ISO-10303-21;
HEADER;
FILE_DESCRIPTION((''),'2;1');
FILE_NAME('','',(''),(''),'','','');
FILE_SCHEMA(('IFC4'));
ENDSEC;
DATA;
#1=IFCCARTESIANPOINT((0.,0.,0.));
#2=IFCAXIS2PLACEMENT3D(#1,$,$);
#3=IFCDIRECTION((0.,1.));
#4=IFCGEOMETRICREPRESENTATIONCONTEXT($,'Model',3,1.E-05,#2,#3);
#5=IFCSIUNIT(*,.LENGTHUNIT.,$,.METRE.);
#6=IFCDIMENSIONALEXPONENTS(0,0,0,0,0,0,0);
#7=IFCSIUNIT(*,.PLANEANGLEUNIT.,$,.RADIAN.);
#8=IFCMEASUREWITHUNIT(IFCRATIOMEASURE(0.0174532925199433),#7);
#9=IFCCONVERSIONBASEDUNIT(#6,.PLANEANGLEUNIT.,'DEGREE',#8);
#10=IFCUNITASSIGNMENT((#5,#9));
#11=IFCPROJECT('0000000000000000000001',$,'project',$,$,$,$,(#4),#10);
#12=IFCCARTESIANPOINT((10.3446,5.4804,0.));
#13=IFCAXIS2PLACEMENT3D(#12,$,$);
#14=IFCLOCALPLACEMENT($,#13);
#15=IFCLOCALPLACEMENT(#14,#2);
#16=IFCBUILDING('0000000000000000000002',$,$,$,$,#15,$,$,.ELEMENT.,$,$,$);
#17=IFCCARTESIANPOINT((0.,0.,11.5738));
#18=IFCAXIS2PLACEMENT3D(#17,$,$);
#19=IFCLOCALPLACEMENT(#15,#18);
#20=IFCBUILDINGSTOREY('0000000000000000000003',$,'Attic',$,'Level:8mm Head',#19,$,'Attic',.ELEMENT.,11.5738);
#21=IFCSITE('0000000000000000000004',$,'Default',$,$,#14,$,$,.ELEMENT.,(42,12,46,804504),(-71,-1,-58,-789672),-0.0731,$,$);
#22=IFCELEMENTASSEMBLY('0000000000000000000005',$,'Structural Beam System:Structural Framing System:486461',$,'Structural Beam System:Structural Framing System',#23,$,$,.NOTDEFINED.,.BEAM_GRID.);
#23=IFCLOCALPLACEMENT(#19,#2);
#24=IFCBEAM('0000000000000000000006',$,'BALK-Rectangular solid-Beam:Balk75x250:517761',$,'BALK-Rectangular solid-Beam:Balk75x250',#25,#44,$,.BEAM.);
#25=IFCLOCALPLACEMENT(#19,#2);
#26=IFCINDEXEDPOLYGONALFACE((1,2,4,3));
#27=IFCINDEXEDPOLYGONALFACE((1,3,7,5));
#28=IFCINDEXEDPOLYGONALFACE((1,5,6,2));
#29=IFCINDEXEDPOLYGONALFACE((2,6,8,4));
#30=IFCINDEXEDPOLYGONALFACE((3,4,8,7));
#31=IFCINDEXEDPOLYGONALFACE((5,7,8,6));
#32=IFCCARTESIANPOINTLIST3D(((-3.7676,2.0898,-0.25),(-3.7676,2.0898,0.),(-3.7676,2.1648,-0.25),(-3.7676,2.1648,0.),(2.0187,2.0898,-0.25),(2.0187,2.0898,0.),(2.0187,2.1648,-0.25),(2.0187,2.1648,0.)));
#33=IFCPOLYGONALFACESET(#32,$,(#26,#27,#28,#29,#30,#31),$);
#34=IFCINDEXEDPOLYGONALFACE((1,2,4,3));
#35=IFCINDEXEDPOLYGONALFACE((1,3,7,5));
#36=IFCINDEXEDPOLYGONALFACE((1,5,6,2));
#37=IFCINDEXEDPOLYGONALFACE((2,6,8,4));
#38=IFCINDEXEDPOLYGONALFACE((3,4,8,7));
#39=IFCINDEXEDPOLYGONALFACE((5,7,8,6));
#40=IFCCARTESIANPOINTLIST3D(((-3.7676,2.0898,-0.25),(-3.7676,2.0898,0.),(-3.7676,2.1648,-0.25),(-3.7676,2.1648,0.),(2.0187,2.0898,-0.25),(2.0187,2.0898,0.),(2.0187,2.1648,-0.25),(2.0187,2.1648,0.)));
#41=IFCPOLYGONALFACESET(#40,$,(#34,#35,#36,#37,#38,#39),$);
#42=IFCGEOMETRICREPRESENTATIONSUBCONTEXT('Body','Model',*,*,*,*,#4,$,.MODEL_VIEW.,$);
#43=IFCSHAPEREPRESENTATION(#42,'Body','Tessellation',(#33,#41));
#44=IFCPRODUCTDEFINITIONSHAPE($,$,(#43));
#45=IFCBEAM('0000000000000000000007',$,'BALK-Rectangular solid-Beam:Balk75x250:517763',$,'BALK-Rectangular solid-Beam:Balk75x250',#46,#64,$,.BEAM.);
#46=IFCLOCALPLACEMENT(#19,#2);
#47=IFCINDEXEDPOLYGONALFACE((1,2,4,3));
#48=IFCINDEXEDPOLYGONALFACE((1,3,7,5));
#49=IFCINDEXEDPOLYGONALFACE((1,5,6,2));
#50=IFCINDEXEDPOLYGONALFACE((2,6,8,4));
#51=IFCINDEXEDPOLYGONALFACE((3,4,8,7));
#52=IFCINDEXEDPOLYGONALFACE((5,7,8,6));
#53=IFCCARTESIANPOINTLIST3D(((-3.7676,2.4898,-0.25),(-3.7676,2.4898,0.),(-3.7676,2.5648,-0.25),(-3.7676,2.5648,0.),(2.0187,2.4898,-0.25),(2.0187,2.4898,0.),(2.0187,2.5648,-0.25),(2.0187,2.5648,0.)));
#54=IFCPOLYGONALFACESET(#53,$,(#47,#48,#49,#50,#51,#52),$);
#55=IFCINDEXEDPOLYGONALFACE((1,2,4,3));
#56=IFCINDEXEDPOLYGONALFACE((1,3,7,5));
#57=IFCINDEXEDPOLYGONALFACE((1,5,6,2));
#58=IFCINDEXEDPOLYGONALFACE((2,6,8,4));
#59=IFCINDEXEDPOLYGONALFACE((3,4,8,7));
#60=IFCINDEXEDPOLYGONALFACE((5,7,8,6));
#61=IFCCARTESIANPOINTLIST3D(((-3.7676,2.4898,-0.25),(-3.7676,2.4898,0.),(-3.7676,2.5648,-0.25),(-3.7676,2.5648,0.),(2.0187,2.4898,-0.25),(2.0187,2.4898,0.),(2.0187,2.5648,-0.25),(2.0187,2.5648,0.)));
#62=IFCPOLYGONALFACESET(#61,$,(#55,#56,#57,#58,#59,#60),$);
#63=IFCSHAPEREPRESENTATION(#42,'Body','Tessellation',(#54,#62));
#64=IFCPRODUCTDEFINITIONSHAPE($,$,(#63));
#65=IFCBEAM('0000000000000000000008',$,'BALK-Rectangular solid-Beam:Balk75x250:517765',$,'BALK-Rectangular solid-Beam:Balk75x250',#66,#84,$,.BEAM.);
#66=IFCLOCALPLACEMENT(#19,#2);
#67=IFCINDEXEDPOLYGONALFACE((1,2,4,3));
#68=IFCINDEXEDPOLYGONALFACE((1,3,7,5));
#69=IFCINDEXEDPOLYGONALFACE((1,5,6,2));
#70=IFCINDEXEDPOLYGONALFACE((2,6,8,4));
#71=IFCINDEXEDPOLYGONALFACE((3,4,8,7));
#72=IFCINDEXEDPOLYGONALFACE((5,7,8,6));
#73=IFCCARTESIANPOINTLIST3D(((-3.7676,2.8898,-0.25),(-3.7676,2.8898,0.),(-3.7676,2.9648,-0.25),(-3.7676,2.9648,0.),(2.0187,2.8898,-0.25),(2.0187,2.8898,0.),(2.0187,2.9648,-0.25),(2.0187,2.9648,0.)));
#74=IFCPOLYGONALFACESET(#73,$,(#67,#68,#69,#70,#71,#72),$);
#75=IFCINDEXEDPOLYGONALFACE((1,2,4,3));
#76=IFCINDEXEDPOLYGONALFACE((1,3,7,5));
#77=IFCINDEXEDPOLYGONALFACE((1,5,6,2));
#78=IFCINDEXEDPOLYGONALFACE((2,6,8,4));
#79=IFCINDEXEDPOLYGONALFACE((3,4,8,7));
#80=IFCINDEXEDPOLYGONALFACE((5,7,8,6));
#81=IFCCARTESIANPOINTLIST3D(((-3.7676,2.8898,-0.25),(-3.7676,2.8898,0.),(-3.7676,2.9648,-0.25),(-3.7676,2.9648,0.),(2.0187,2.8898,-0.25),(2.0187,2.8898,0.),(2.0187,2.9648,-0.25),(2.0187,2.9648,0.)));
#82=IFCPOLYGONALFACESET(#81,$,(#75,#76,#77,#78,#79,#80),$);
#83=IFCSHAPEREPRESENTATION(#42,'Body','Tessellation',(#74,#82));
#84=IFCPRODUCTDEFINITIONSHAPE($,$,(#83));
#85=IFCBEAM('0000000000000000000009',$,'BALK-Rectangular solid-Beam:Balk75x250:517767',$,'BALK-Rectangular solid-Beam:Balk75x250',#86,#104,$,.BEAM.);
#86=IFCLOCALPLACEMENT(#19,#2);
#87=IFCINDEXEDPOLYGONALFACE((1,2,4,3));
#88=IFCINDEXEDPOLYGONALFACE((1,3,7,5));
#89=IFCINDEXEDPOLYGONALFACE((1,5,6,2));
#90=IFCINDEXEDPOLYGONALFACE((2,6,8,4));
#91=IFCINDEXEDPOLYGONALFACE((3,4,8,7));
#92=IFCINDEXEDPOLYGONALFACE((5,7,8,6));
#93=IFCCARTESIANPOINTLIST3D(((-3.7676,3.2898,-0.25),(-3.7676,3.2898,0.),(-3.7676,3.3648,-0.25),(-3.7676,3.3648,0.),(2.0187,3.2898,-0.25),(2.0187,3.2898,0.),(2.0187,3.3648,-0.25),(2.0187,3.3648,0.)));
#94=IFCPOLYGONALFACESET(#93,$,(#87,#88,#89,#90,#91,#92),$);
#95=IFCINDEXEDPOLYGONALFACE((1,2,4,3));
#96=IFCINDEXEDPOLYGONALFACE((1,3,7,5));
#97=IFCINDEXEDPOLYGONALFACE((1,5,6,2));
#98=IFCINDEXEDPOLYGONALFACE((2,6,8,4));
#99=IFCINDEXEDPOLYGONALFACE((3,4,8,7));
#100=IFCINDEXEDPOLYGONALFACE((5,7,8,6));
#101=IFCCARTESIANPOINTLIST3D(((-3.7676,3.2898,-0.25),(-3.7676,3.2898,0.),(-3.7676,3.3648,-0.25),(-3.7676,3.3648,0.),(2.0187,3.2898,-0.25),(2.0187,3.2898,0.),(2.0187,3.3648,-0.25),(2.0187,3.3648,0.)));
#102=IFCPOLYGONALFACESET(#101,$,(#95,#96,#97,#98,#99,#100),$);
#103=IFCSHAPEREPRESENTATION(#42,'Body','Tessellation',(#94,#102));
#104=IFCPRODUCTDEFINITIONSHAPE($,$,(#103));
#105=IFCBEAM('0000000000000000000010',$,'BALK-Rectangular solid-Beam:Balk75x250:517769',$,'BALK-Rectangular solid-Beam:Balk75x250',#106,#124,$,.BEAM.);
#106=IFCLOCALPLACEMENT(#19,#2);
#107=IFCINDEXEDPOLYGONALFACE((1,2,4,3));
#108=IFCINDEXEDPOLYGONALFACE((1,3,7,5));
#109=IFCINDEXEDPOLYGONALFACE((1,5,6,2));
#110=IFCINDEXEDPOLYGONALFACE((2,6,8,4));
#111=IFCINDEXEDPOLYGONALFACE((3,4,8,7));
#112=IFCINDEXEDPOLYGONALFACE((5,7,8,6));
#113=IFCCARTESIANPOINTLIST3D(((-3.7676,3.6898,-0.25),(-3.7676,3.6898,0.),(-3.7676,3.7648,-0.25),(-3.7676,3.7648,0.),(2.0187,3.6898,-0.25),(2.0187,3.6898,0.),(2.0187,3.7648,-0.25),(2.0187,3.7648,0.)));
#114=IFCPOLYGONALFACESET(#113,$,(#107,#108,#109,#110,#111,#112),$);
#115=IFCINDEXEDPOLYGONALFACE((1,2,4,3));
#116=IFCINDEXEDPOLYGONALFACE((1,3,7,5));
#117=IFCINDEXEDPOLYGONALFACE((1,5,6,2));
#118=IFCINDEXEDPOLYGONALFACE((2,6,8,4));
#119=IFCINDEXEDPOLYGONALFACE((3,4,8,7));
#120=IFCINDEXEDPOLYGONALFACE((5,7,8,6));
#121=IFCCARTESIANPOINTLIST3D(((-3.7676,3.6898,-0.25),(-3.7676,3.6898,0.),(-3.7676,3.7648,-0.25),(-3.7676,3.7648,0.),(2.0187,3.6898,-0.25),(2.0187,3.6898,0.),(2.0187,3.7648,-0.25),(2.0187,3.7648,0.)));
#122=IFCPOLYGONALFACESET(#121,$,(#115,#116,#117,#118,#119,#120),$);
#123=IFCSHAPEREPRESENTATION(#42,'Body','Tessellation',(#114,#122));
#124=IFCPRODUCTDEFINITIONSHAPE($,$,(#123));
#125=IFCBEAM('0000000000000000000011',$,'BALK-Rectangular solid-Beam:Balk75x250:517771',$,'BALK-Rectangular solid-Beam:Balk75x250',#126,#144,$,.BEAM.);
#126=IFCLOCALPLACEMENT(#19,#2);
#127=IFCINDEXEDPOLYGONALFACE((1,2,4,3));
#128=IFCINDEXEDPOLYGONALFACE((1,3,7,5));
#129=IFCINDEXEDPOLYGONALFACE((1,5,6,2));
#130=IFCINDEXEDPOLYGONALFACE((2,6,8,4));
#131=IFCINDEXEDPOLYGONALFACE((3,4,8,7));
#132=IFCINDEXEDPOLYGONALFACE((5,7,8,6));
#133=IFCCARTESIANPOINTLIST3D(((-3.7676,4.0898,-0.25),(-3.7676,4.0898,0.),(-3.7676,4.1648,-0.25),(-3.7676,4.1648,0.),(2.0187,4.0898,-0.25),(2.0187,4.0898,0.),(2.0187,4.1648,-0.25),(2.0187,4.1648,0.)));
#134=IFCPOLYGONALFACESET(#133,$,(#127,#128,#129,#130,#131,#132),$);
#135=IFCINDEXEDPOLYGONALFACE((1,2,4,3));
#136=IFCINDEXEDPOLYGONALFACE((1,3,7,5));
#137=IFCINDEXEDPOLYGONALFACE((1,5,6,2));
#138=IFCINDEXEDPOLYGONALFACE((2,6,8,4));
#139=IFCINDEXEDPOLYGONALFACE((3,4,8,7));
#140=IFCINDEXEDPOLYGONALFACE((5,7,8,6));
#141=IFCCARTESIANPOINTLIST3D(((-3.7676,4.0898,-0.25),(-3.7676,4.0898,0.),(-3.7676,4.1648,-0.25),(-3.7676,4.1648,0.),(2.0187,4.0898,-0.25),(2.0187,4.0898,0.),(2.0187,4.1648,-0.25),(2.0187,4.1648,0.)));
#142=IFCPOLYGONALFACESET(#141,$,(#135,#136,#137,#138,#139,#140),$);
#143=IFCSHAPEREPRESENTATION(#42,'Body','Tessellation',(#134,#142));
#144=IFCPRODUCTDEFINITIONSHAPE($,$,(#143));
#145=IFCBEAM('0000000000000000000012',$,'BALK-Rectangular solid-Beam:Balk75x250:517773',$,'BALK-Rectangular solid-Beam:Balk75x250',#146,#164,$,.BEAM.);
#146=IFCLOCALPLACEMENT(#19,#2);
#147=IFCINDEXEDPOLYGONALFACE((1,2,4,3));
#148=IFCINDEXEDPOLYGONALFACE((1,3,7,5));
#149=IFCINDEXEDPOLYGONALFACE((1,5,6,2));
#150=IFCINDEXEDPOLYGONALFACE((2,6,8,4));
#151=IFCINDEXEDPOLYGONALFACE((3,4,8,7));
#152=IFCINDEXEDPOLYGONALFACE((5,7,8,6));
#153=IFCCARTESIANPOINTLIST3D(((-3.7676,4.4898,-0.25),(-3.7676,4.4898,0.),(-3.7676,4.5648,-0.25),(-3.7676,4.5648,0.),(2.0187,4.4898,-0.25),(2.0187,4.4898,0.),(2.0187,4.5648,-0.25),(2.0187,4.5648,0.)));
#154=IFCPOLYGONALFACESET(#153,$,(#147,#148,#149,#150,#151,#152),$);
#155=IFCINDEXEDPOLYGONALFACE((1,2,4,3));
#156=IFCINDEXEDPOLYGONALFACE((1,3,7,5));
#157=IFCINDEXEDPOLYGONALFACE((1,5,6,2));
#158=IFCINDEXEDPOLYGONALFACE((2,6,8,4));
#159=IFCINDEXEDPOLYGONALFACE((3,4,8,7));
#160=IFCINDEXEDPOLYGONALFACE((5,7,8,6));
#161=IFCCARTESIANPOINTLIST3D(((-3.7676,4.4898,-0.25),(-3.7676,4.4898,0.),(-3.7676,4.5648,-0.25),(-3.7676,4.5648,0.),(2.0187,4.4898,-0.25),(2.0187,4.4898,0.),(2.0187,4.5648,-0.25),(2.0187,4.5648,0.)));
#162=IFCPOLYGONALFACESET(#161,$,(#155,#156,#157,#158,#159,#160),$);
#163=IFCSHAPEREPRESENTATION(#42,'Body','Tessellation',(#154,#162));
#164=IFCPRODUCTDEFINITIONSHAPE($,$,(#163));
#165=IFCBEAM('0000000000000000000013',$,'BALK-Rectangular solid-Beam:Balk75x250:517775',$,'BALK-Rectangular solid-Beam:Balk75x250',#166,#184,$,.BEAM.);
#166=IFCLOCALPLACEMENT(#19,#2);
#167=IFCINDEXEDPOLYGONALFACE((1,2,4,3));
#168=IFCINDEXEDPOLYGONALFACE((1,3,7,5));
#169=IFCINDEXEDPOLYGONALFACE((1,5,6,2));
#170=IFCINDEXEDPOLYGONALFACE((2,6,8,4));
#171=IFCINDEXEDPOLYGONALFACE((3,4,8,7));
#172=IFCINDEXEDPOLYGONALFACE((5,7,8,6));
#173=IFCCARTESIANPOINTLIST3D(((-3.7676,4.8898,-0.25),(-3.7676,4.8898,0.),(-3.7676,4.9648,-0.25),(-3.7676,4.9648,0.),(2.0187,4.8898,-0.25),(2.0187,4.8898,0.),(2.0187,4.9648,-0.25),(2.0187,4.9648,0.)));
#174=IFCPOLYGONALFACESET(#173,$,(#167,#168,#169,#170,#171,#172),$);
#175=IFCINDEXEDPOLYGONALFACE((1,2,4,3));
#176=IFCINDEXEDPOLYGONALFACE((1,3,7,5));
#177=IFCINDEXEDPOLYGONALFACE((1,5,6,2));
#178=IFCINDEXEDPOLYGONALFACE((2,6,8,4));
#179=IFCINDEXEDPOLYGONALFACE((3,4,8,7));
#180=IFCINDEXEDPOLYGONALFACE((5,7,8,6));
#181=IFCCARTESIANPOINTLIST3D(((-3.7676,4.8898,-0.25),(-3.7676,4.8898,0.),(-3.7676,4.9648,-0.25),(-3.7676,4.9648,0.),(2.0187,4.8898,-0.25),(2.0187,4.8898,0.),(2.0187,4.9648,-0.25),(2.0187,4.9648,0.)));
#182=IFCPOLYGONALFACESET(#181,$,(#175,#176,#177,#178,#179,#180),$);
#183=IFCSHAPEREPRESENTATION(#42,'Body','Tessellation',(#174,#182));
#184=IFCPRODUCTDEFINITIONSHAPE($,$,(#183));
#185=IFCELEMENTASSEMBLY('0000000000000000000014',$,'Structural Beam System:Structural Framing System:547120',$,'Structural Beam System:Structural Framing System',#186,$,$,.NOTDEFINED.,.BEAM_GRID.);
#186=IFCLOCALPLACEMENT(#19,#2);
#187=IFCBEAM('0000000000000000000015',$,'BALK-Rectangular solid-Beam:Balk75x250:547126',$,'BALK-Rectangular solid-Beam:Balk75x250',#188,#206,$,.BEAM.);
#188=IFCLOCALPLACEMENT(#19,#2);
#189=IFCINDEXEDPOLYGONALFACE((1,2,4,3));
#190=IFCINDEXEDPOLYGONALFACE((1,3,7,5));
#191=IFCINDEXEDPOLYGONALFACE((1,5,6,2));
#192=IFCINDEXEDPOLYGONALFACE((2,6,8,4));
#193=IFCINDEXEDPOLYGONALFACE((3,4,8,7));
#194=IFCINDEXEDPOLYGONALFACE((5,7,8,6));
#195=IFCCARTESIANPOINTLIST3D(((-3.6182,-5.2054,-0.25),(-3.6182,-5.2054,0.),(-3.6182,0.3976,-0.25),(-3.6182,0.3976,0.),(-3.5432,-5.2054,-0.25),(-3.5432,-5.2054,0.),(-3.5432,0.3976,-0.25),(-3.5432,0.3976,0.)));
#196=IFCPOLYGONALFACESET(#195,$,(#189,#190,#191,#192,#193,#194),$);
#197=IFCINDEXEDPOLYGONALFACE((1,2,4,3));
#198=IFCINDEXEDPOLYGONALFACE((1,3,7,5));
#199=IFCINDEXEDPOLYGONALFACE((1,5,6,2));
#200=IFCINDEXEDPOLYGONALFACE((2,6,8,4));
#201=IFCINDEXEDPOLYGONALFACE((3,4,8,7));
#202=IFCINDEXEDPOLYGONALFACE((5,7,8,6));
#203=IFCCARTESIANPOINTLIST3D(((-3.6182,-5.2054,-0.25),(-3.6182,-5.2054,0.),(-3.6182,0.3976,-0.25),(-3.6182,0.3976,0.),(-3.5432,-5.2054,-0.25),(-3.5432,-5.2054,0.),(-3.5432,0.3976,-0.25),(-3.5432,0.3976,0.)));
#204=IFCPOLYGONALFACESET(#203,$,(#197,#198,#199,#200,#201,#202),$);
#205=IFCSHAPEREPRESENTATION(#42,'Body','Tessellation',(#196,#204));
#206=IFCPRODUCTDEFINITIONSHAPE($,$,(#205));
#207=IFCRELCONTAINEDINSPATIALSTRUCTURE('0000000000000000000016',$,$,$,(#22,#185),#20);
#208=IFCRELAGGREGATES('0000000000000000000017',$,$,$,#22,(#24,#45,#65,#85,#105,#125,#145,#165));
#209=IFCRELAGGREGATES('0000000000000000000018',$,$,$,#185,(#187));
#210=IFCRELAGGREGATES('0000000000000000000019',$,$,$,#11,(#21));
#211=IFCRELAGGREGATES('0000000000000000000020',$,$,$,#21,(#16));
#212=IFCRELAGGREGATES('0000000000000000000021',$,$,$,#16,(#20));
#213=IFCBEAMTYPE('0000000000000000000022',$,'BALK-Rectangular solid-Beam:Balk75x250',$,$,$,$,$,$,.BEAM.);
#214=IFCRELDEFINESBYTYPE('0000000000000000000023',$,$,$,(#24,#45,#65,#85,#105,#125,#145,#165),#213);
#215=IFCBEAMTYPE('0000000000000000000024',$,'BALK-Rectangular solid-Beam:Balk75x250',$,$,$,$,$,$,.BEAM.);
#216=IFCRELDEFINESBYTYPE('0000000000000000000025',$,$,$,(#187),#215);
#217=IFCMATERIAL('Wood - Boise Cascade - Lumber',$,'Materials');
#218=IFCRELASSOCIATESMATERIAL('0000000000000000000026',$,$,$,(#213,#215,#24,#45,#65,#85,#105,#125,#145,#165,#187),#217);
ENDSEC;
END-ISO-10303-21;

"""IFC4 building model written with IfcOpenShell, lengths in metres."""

from ifc_helpers import new_model, entity, si_unit, converted_unit, direction, frame, frame_2d, origin, origin_2d_with_axis, place, context, subcontext, project, spatial, rectangle, extrude, source, transform, mapped, material, material_profile, profile_set, profile_usage, type_object, type_shapes, element, aggregate, save


model = new_model("IFC4")

# Units and contexts
model_context = context("Model", 3, precision=1e-05, world=origin(), true_north=direction((0.0, 1.0)))
body_context = subcontext(model_context, "Body", "Model", "MODEL_VIEW")
ifc_project = project(units=[si_unit("LENGTHUNIT", "METRE"), converted_unit("PLANEANGLEUNIT", "DEGREE", entity("IfcRatioMeasure", 0.0174532925199433), si_unit("PLANEANGLEUNIT", "RADIAN"), dimensions=[0, 0, 0, 0, 0, 0, 0])], contexts=[model_context])

# Site, building, storey
site_placement = place(None, frame((10.3446, 5.4804, 0.0)))
site = spatial("IfcSite", under=ifc_project, at=site_placement, Name="Default", CompositionType="ELEMENT", RefLatitude=(42, 12, 46, 804504), RefLongitude=(-71, -1, -58, -789672), RefElevation=-0.0731)
building_placement = place(site_placement, origin())
building = spatial("IfcBuilding", under=site, at=building_placement, CompositionType="ELEMENT")
storey_placement = place(building_placement, frame((0.0, 0.0, 11.5738)))
storey = spatial("IfcBuildingStorey", under=building, at=storey_placement, Name="Attic", ObjectType="Level:8mm Head", LongName="Attic", CompositionType="ELEMENT", Elevation=11.5738)

# Element assembly
ifc_material = material(Name="Wood - Boise Cascade - Lumber", Category="Materials")
ifc_material_profile = material_profile(ifc_material, rectangle(XDim=0.25, YDim=0.075, at=frame_2d((0.0, 0.0), x_axis=(1.0, 0.0))), Name="Balk75x250")
ifc_profile_set = profile_set([ifc_material_profile], Name="Balk75x250")
assembly_1_placement = place(storey_placement, origin())
assembly_1 = element("IfcElementAssembly", 1, at=assembly_1_placement, inside=storey, Name="Structural Beam System:Structural Framing System:486461", ObjectType="Structural Beam System:Structural Framing System", AssemblyPlace="NOTDEFINED", PredefinedType="BEAM_GRID")

# Beams
beam_type_1 = type_object("IfcBeamType", Name="BALK-Rectangular solid-Beam:Balk75x250", PredefinedType="BEAM", material=ifc_profile_set)
shared_shape_1 = source(origin(), body_context, "Body", "SweptSolid", [
    extrude(rectangle(XDim=0.25, YDim=0.075, at=origin_2d_with_axis()), frame((-2.7994, 0.0, 0.0), z_axis=(1.0, 0.0, 0.0), x_axis=(0.0, 0.0, -1.0)), (0.0, 0.0, 1.0), 5.7863),
    extrude(rectangle(XDim=0.25, YDim=0.075, at=origin_2d_with_axis()), frame((-2.7994, 0.0, 0.0), z_axis=(1.0, 0.0, 0.0), x_axis=(0.0, 0.0, -1.0)), (0.0, 0.0, 1.0), 5.7863),
])
type_shapes(beam_type_1, [shared_shape_1])
ifc_profile_usage_1 = profile_usage(ifc_profile_set, cardinal=8)
beam_1_placement = place(assembly_1_placement, frame((-0.7807, 2.1273, -0.125), z_axis=(0.0, 0.0, 1.0), x_axis=(-1.0, 0.0, 0.0)))
beam_1 = element("IfcBeam", 2, at=beam_1_placement, type_object=beam_type_1, material=ifc_profile_usage_1, Name="BALK-Rectangular solid-Beam:Balk75x250:517761", ObjectType="BALK-Rectangular solid-Beam:Balk75x250", PredefinedType="BEAM", context=body_context, shape_type="MappedRepresentation", body=[
    mapped(shared_shape_1, transform((0.0, 0.0, 0.0), scale=1.0)),
])
ifc_profile_usage_2 = profile_usage(ifc_profile_set, cardinal=8)
beam_2_placement = place(assembly_1_placement, frame((-0.7807, 2.5273, -0.125), z_axis=(0.0, 0.0, 1.0), x_axis=(-1.0, 0.0, 0.0)))
beam_2 = element("IfcBeam", 3, at=beam_2_placement, type_object=beam_type_1, material=ifc_profile_usage_2, Name="BALK-Rectangular solid-Beam:Balk75x250:517763", ObjectType="BALK-Rectangular solid-Beam:Balk75x250", PredefinedType="BEAM", context=body_context, shape_type="MappedRepresentation", body=[
    mapped(shared_shape_1, transform((0.0, 0.0, 0.0), scale=1.0)),
])
ifc_profile_usage_3 = profile_usage(ifc_profile_set, cardinal=8)
beam_3_placement = place(assembly_1_placement, frame((-0.7807, 2.9273, -0.125), z_axis=(0.0, 0.0, 1.0), x_axis=(-1.0, 0.0, 0.0)))
beam_3 = element("IfcBeam", 4, at=beam_3_placement, type_object=beam_type_1, material=ifc_profile_usage_3, Name="BALK-Rectangular solid-Beam:Balk75x250:517765", ObjectType="BALK-Rectangular solid-Beam:Balk75x250", PredefinedType="BEAM", context=body_context, shape_type="MappedRepresentation", body=[
    mapped(shared_shape_1, transform((0.0, 0.0, 0.0), scale=1.0)),
])
ifc_profile_usage_4 = profile_usage(ifc_profile_set, cardinal=8)
beam_4_placement = place(assembly_1_placement, frame((-0.7807, 3.3273, -0.125), z_axis=(0.0, 0.0, 1.0), x_axis=(-1.0, 0.0, 0.0)))
beam_4 = element("IfcBeam", 5, at=beam_4_placement, type_object=beam_type_1, material=ifc_profile_usage_4, Name="BALK-Rectangular solid-Beam:Balk75x250:517767", ObjectType="BALK-Rectangular solid-Beam:Balk75x250", PredefinedType="BEAM", context=body_context, shape_type="MappedRepresentation", body=[
    mapped(shared_shape_1, transform((0.0, 0.0, 0.0), scale=1.0)),
])
ifc_profile_usage_5 = profile_usage(ifc_profile_set, cardinal=8)
beam_5_placement = place(assembly_1_placement, frame((-0.7807, 3.7273, -0.125), z_axis=(0.0, 0.0, 1.0), x_axis=(-1.0, 0.0, 0.0)))
beam_5 = element("IfcBeam", 6, at=beam_5_placement, type_object=beam_type_1, material=ifc_profile_usage_5, Name="BALK-Rectangular solid-Beam:Balk75x250:517769", ObjectType="BALK-Rectangular solid-Beam:Balk75x250", PredefinedType="BEAM", context=body_context, shape_type="MappedRepresentation", body=[
    mapped(shared_shape_1, transform((0.0, 0.0, 0.0), scale=1.0)),
])
ifc_profile_usage_6 = profile_usage(ifc_profile_set, cardinal=8)
beam_6_placement = place(assembly_1_placement, frame((-0.7807, 4.1273, -0.125), z_axis=(0.0, 0.0, 1.0), x_axis=(-1.0, 0.0, 0.0)))
beam_6 = element("IfcBeam", 7, at=beam_6_placement, type_object=beam_type_1, material=ifc_profile_usage_6, Name="BALK-Rectangular solid-Beam:Balk75x250:517771", ObjectType="BALK-Rectangular solid-Beam:Balk75x250", PredefinedType="BEAM", context=body_context, shape_type="MappedRepresentation", body=[
    mapped(shared_shape_1, transform((0.0, 0.0, 0.0), scale=1.0)),
])
ifc_profile_usage_7 = profile_usage(ifc_profile_set, cardinal=8)
beam_7_placement = place(assembly_1_placement, frame((-0.7807, 4.5273, -0.125), z_axis=(0.0, 0.0, 1.0), x_axis=(-1.0, 0.0, 0.0)))
beam_7 = element("IfcBeam", 8, at=beam_7_placement, type_object=beam_type_1, material=ifc_profile_usage_7, Name="BALK-Rectangular solid-Beam:Balk75x250:517773", ObjectType="BALK-Rectangular solid-Beam:Balk75x250", PredefinedType="BEAM", context=body_context, shape_type="MappedRepresentation", body=[
    mapped(shared_shape_1, transform((0.0, 0.0, 0.0), scale=1.0)),
])
ifc_profile_usage_8 = profile_usage(ifc_profile_set, cardinal=8)
beam_8_placement = place(assembly_1_placement, frame((-0.7807, 4.9273, -0.125), z_axis=(0.0, 0.0, 1.0), x_axis=(-1.0, 0.0, 0.0)))
beam_8 = element("IfcBeam", 9, at=beam_8_placement, type_object=beam_type_1, material=ifc_profile_usage_8, Name="BALK-Rectangular solid-Beam:Balk75x250:517775", ObjectType="BALK-Rectangular solid-Beam:Balk75x250", PredefinedType="BEAM", context=body_context, shape_type="MappedRepresentation", body=[
    mapped(shared_shape_1, transform((0.0, 0.0, 0.0), scale=1.0)),
])
aggregate(assembly_1, [beam_1, beam_2, beam_3, beam_4, beam_5, beam_6, beam_7, beam_8])

# Element assembly, beam
assembly_2_placement = place(storey_placement, origin())
assembly_2 = element("IfcElementAssembly", 10, at=assembly_2_placement, inside=storey, Name="Structural Beam System:Structural Framing System:547120", ObjectType="Structural Beam System:Structural Framing System", AssemblyPlace="NOTDEFINED", PredefinedType="BEAM_GRID")
ifc_profile_usage_9 = profile_usage(ifc_profile_set, cardinal=8)
beam_type_2 = type_object("IfcBeamType", Name="BALK-Rectangular solid-Beam:Balk75x250", PredefinedType="BEAM", material=ifc_profile_set)
shared_shape_2 = source(origin(), body_context, "Body", "SweptSolid", [
    extrude(rectangle(XDim=0.25, YDim=0.075, at=origin_2d_with_axis()), frame((-2.6953, 0.0, 0.0), z_axis=(1.0, 0.0, 0.0), x_axis=(0.0, 0.0, -1.0)), (0.0, 0.0, 1.0), 5.603),
    extrude(rectangle(XDim=0.25, YDim=0.075, at=origin_2d_with_axis()), frame((-2.6953, 0.0, 0.0), z_axis=(1.0, 0.0, 0.0), x_axis=(0.0, 0.0, -1.0)), (0.0, 0.0, 1.0), 5.603),
])
type_shapes(beam_type_2, [shared_shape_2])
beam_9_placement = place(assembly_2_placement, frame((-3.5807, -2.5102, -0.125), z_axis=(0.0, 0.0, 1.0), x_axis=(0.0, 1.0, 0.0)))
beam_9 = element("IfcBeam", 11, at=beam_9_placement, type_object=beam_type_2, material=ifc_profile_usage_9, Name="BALK-Rectangular solid-Beam:Balk75x250:547126", ObjectType="BALK-Rectangular solid-Beam:Balk75x250", PredefinedType="BEAM", context=body_context, shape_type="MappedRepresentation", body=[
    mapped(shared_shape_2, transform((0.0, 0.0, 0.0), scale=1.0)),
])
aggregate(assembly_2, [beam_9])

save(model, "model.ifc")
